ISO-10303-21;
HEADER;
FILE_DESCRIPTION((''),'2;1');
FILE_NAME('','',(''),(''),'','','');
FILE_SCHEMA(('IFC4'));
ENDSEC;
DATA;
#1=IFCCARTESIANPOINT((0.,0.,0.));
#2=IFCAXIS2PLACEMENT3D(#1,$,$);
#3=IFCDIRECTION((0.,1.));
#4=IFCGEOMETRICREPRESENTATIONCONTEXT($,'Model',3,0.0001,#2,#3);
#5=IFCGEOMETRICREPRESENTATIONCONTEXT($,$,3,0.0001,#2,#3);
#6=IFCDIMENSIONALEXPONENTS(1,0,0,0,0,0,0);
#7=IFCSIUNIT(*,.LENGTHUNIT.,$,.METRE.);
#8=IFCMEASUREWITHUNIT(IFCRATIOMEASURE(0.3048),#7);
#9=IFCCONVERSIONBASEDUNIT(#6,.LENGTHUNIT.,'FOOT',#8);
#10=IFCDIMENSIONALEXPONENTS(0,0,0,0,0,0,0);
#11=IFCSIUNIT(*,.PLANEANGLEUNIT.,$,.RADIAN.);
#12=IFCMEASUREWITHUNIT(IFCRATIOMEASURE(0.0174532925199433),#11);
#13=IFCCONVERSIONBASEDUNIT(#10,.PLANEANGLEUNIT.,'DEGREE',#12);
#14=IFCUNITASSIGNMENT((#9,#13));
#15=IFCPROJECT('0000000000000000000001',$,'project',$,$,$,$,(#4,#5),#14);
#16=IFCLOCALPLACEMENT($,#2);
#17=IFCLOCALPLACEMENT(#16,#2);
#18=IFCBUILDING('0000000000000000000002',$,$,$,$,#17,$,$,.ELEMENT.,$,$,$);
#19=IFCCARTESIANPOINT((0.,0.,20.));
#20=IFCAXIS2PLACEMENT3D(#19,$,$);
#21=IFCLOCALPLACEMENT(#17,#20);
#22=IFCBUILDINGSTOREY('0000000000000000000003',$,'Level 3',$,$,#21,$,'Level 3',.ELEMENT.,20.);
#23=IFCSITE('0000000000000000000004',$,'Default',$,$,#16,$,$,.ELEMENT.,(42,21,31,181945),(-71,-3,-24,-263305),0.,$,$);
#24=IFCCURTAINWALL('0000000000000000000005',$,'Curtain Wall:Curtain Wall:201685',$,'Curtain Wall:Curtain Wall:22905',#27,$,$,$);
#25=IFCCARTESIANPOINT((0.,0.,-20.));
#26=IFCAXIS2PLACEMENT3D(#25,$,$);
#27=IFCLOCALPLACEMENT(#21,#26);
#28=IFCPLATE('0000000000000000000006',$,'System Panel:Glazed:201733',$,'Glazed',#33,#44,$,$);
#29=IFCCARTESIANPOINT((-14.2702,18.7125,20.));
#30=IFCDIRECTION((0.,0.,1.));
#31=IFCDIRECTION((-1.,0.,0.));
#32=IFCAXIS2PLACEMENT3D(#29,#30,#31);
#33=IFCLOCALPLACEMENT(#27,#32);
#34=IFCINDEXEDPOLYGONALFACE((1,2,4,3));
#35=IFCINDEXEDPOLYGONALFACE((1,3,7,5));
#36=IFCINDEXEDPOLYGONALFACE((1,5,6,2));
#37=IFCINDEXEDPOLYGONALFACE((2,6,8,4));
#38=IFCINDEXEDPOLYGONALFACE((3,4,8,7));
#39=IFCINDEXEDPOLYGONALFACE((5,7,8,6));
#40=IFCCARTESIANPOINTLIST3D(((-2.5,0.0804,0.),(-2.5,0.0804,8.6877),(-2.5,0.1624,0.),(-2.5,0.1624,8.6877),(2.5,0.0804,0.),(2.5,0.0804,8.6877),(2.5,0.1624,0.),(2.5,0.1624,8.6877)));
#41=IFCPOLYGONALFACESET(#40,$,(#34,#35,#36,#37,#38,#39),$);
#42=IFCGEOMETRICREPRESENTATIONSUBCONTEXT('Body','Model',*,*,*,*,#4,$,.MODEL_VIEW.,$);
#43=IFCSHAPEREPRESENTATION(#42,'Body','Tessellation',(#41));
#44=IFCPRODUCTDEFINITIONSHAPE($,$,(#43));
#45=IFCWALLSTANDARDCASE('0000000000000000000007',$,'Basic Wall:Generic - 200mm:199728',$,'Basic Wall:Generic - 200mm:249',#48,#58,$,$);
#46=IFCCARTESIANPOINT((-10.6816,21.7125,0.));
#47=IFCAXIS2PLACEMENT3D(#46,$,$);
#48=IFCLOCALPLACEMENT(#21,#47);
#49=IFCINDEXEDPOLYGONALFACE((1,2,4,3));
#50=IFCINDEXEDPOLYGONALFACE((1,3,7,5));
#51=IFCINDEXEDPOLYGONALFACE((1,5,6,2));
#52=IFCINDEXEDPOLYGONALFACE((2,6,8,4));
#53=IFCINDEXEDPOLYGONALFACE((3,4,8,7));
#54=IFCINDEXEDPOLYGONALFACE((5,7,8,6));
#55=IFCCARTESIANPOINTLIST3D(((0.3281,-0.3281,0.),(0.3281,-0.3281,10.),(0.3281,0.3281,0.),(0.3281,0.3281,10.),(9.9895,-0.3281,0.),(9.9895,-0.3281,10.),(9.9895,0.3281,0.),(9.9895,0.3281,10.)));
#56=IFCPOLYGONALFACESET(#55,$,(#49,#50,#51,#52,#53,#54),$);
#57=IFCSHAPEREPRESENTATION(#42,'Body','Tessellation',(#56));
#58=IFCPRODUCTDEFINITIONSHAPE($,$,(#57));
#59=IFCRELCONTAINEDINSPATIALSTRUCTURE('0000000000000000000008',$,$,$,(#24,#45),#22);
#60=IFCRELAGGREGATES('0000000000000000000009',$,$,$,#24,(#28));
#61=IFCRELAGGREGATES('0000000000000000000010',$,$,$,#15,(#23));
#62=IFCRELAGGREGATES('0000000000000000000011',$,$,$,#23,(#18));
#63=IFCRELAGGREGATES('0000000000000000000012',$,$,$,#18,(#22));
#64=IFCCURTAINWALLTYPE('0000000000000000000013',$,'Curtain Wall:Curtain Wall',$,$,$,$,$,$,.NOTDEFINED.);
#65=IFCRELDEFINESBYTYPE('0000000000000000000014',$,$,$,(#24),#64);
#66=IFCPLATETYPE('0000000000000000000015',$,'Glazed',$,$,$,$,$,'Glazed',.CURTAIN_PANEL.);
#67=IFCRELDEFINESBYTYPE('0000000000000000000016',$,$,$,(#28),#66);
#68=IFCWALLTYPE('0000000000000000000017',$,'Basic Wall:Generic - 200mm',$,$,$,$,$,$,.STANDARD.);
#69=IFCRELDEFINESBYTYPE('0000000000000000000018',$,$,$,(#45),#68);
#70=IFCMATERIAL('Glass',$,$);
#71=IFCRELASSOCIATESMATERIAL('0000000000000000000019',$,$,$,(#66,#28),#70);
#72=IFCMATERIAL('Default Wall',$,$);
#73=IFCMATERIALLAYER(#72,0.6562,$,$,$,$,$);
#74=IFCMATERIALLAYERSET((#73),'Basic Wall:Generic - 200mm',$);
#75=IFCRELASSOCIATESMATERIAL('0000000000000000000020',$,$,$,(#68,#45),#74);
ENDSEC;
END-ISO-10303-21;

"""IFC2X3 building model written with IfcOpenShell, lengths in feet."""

from ifc_helpers import new_model, entity, si_unit, converted_unit, direction, frame, frame_2d, origin, origin_2d_with_axis, place, context, subcontext, project, spatial, rectangle, extrude, clip, halfspace, source, transform, mapped, material, layer, layer_set, layer_usage, type_object, type_shapes, element, aggregate, save


model = new_model("IFC2X3")

# Units and contexts
model_context = context("Model", 3, precision=0.0001, world=origin(), true_north=direction((0.0, 1.0)))
context_of_model = context(None, 3, precision=0.0001, world=origin(), true_north=direction((0.0, 1.0)))
body_context = subcontext(model_context, "Body", "Model", "MODEL_VIEW")
ifc_project = project(units=[converted_unit("LENGTHUNIT", "FOOT", entity("IfcRatioMeasure", 0.3048), si_unit("LENGTHUNIT", "METRE"), dimensions=[1, 0, 0, 0, 0, 0, 0]), converted_unit("PLANEANGLEUNIT", "DEGREE", entity("IfcRatioMeasure", 0.0174532925199433), si_unit("PLANEANGLEUNIT", "RADIAN"), dimensions=[0, 0, 0, 0, 0, 0, 0])], contexts=[model_context, context_of_model])

# Site, building, storey
site_placement = place(None, origin())
site = spatial("IfcSite", under=ifc_project, at=site_placement, Name="Default", CompositionType="ELEMENT", RefLatitude=(42, 21, 31, 181945), RefLongitude=(-71, -3, -24, -263305), RefElevation=0.0)
building_placement = place(site_placement, origin())
building = spatial("IfcBuilding", under=site, at=building_placement, CompositionType="ELEMENT")
storey_placement = place(building_placement, frame((0.0, 0.0, 20.0)))
storey = spatial("IfcBuildingStorey", under=building, at=storey_placement, Name="Level 3", LongName="Level 3", CompositionType="ELEMENT", Elevation=20.0)

# Curtain wall, plate
curtain_wall_type = type_object("IfcCurtainWallType", Name="Curtain Wall:Curtain Wall", PredefinedType="NOTDEFINED")
curtain_wall_placement = place(storey_placement, frame((0.0, 0.0, -20.0)))
curtain_wall = element("IfcCurtainWall", 1, at=curtain_wall_placement, inside=storey, type_object=curtain_wall_type, Name="Curtain Wall:Curtain Wall:201685", ObjectType="Curtain Wall:Curtain Wall:22905")
ifc_material_1 = material(Name="Glass")
plate_type = type_object("IfcPlateType", Name="Glazed", ElementType="Glazed", PredefinedType="CURTAIN_PANEL", material=ifc_material_1)
shared_shape_1 = source(origin(), body_context, "Body", "SweptSolid", [
    extrude(rectangle(XDim=0.082, YDim=5.0, at=origin_2d_with_axis()), frame((0.0, 0.1214, 0.0), z_axis=(0.0, 0.0, 1.0), x_axis=(0.0, 1.0, 0.0)), (0.0, 0.0, 1.0), 8.6877),
])
type_shapes(plate_type, [shared_shape_1])
plate_placement = place(curtain_wall_placement, frame((-14.2702, 18.7125, 20.0), z_axis=(0.0, 0.0, 1.0), x_axis=(-1.0, 0.0, 0.0)))
plate = element("IfcPlate", 2, at=plate_placement, type_object=plate_type, material=ifc_material_1, Name="System Panel:Glazed:201733", ObjectType="Glazed", context=body_context, shape_type="MappedRepresentation", body=[
    mapped(shared_shape_1, transform((0.0, 0.0, 0.0), scale=1.0)),
])
aggregate(curtain_wall, [plate])

# Shared definitions
ifc_material_2 = material(Name="Default Wall")

# Wall
ifc_layer_1 = layer(ifc_material_2, 0.6562)
ifc_layer_set_1 = layer_set([ifc_layer_1], Name="Basic Wall:Generic - 200mm")
wall_type_1 = type_object("IfcWallType", Name="Basic Wall:Generic - 200mm", PredefinedType="STANDARD", material=ifc_layer_set_1)
ifc_layer_usage_1 = layer_usage(ifc_layer_set_1, "AXIS2", "NEGATIVE", 0.3281)
wall_1_placement = place(storey_placement, frame((-10.6816, 21.7125, 0.0)))
element("IfcWallStandardCase", 3, at=wall_1_placement, inside=storey, type_object=wall_type_1, material=ifc_layer_usage_1, Name="Basic Wall:Generic - 200mm:199728", ObjectType="Basic Wall:Generic - 200mm:249", context=body_context, shape_type="Clipping", body=[
    clip(extrude(rectangle(XDim=9.6614, YDim=0.6562, at=frame_2d((5.1588, 0.0), x_axis=(-1.0, 0.0))), origin(), (0.0, 0.0, 1.0), 10.0), halfspace(frame((0.0, 0.0, -20.0)), True)),
])

save(model, "model.ifc")
